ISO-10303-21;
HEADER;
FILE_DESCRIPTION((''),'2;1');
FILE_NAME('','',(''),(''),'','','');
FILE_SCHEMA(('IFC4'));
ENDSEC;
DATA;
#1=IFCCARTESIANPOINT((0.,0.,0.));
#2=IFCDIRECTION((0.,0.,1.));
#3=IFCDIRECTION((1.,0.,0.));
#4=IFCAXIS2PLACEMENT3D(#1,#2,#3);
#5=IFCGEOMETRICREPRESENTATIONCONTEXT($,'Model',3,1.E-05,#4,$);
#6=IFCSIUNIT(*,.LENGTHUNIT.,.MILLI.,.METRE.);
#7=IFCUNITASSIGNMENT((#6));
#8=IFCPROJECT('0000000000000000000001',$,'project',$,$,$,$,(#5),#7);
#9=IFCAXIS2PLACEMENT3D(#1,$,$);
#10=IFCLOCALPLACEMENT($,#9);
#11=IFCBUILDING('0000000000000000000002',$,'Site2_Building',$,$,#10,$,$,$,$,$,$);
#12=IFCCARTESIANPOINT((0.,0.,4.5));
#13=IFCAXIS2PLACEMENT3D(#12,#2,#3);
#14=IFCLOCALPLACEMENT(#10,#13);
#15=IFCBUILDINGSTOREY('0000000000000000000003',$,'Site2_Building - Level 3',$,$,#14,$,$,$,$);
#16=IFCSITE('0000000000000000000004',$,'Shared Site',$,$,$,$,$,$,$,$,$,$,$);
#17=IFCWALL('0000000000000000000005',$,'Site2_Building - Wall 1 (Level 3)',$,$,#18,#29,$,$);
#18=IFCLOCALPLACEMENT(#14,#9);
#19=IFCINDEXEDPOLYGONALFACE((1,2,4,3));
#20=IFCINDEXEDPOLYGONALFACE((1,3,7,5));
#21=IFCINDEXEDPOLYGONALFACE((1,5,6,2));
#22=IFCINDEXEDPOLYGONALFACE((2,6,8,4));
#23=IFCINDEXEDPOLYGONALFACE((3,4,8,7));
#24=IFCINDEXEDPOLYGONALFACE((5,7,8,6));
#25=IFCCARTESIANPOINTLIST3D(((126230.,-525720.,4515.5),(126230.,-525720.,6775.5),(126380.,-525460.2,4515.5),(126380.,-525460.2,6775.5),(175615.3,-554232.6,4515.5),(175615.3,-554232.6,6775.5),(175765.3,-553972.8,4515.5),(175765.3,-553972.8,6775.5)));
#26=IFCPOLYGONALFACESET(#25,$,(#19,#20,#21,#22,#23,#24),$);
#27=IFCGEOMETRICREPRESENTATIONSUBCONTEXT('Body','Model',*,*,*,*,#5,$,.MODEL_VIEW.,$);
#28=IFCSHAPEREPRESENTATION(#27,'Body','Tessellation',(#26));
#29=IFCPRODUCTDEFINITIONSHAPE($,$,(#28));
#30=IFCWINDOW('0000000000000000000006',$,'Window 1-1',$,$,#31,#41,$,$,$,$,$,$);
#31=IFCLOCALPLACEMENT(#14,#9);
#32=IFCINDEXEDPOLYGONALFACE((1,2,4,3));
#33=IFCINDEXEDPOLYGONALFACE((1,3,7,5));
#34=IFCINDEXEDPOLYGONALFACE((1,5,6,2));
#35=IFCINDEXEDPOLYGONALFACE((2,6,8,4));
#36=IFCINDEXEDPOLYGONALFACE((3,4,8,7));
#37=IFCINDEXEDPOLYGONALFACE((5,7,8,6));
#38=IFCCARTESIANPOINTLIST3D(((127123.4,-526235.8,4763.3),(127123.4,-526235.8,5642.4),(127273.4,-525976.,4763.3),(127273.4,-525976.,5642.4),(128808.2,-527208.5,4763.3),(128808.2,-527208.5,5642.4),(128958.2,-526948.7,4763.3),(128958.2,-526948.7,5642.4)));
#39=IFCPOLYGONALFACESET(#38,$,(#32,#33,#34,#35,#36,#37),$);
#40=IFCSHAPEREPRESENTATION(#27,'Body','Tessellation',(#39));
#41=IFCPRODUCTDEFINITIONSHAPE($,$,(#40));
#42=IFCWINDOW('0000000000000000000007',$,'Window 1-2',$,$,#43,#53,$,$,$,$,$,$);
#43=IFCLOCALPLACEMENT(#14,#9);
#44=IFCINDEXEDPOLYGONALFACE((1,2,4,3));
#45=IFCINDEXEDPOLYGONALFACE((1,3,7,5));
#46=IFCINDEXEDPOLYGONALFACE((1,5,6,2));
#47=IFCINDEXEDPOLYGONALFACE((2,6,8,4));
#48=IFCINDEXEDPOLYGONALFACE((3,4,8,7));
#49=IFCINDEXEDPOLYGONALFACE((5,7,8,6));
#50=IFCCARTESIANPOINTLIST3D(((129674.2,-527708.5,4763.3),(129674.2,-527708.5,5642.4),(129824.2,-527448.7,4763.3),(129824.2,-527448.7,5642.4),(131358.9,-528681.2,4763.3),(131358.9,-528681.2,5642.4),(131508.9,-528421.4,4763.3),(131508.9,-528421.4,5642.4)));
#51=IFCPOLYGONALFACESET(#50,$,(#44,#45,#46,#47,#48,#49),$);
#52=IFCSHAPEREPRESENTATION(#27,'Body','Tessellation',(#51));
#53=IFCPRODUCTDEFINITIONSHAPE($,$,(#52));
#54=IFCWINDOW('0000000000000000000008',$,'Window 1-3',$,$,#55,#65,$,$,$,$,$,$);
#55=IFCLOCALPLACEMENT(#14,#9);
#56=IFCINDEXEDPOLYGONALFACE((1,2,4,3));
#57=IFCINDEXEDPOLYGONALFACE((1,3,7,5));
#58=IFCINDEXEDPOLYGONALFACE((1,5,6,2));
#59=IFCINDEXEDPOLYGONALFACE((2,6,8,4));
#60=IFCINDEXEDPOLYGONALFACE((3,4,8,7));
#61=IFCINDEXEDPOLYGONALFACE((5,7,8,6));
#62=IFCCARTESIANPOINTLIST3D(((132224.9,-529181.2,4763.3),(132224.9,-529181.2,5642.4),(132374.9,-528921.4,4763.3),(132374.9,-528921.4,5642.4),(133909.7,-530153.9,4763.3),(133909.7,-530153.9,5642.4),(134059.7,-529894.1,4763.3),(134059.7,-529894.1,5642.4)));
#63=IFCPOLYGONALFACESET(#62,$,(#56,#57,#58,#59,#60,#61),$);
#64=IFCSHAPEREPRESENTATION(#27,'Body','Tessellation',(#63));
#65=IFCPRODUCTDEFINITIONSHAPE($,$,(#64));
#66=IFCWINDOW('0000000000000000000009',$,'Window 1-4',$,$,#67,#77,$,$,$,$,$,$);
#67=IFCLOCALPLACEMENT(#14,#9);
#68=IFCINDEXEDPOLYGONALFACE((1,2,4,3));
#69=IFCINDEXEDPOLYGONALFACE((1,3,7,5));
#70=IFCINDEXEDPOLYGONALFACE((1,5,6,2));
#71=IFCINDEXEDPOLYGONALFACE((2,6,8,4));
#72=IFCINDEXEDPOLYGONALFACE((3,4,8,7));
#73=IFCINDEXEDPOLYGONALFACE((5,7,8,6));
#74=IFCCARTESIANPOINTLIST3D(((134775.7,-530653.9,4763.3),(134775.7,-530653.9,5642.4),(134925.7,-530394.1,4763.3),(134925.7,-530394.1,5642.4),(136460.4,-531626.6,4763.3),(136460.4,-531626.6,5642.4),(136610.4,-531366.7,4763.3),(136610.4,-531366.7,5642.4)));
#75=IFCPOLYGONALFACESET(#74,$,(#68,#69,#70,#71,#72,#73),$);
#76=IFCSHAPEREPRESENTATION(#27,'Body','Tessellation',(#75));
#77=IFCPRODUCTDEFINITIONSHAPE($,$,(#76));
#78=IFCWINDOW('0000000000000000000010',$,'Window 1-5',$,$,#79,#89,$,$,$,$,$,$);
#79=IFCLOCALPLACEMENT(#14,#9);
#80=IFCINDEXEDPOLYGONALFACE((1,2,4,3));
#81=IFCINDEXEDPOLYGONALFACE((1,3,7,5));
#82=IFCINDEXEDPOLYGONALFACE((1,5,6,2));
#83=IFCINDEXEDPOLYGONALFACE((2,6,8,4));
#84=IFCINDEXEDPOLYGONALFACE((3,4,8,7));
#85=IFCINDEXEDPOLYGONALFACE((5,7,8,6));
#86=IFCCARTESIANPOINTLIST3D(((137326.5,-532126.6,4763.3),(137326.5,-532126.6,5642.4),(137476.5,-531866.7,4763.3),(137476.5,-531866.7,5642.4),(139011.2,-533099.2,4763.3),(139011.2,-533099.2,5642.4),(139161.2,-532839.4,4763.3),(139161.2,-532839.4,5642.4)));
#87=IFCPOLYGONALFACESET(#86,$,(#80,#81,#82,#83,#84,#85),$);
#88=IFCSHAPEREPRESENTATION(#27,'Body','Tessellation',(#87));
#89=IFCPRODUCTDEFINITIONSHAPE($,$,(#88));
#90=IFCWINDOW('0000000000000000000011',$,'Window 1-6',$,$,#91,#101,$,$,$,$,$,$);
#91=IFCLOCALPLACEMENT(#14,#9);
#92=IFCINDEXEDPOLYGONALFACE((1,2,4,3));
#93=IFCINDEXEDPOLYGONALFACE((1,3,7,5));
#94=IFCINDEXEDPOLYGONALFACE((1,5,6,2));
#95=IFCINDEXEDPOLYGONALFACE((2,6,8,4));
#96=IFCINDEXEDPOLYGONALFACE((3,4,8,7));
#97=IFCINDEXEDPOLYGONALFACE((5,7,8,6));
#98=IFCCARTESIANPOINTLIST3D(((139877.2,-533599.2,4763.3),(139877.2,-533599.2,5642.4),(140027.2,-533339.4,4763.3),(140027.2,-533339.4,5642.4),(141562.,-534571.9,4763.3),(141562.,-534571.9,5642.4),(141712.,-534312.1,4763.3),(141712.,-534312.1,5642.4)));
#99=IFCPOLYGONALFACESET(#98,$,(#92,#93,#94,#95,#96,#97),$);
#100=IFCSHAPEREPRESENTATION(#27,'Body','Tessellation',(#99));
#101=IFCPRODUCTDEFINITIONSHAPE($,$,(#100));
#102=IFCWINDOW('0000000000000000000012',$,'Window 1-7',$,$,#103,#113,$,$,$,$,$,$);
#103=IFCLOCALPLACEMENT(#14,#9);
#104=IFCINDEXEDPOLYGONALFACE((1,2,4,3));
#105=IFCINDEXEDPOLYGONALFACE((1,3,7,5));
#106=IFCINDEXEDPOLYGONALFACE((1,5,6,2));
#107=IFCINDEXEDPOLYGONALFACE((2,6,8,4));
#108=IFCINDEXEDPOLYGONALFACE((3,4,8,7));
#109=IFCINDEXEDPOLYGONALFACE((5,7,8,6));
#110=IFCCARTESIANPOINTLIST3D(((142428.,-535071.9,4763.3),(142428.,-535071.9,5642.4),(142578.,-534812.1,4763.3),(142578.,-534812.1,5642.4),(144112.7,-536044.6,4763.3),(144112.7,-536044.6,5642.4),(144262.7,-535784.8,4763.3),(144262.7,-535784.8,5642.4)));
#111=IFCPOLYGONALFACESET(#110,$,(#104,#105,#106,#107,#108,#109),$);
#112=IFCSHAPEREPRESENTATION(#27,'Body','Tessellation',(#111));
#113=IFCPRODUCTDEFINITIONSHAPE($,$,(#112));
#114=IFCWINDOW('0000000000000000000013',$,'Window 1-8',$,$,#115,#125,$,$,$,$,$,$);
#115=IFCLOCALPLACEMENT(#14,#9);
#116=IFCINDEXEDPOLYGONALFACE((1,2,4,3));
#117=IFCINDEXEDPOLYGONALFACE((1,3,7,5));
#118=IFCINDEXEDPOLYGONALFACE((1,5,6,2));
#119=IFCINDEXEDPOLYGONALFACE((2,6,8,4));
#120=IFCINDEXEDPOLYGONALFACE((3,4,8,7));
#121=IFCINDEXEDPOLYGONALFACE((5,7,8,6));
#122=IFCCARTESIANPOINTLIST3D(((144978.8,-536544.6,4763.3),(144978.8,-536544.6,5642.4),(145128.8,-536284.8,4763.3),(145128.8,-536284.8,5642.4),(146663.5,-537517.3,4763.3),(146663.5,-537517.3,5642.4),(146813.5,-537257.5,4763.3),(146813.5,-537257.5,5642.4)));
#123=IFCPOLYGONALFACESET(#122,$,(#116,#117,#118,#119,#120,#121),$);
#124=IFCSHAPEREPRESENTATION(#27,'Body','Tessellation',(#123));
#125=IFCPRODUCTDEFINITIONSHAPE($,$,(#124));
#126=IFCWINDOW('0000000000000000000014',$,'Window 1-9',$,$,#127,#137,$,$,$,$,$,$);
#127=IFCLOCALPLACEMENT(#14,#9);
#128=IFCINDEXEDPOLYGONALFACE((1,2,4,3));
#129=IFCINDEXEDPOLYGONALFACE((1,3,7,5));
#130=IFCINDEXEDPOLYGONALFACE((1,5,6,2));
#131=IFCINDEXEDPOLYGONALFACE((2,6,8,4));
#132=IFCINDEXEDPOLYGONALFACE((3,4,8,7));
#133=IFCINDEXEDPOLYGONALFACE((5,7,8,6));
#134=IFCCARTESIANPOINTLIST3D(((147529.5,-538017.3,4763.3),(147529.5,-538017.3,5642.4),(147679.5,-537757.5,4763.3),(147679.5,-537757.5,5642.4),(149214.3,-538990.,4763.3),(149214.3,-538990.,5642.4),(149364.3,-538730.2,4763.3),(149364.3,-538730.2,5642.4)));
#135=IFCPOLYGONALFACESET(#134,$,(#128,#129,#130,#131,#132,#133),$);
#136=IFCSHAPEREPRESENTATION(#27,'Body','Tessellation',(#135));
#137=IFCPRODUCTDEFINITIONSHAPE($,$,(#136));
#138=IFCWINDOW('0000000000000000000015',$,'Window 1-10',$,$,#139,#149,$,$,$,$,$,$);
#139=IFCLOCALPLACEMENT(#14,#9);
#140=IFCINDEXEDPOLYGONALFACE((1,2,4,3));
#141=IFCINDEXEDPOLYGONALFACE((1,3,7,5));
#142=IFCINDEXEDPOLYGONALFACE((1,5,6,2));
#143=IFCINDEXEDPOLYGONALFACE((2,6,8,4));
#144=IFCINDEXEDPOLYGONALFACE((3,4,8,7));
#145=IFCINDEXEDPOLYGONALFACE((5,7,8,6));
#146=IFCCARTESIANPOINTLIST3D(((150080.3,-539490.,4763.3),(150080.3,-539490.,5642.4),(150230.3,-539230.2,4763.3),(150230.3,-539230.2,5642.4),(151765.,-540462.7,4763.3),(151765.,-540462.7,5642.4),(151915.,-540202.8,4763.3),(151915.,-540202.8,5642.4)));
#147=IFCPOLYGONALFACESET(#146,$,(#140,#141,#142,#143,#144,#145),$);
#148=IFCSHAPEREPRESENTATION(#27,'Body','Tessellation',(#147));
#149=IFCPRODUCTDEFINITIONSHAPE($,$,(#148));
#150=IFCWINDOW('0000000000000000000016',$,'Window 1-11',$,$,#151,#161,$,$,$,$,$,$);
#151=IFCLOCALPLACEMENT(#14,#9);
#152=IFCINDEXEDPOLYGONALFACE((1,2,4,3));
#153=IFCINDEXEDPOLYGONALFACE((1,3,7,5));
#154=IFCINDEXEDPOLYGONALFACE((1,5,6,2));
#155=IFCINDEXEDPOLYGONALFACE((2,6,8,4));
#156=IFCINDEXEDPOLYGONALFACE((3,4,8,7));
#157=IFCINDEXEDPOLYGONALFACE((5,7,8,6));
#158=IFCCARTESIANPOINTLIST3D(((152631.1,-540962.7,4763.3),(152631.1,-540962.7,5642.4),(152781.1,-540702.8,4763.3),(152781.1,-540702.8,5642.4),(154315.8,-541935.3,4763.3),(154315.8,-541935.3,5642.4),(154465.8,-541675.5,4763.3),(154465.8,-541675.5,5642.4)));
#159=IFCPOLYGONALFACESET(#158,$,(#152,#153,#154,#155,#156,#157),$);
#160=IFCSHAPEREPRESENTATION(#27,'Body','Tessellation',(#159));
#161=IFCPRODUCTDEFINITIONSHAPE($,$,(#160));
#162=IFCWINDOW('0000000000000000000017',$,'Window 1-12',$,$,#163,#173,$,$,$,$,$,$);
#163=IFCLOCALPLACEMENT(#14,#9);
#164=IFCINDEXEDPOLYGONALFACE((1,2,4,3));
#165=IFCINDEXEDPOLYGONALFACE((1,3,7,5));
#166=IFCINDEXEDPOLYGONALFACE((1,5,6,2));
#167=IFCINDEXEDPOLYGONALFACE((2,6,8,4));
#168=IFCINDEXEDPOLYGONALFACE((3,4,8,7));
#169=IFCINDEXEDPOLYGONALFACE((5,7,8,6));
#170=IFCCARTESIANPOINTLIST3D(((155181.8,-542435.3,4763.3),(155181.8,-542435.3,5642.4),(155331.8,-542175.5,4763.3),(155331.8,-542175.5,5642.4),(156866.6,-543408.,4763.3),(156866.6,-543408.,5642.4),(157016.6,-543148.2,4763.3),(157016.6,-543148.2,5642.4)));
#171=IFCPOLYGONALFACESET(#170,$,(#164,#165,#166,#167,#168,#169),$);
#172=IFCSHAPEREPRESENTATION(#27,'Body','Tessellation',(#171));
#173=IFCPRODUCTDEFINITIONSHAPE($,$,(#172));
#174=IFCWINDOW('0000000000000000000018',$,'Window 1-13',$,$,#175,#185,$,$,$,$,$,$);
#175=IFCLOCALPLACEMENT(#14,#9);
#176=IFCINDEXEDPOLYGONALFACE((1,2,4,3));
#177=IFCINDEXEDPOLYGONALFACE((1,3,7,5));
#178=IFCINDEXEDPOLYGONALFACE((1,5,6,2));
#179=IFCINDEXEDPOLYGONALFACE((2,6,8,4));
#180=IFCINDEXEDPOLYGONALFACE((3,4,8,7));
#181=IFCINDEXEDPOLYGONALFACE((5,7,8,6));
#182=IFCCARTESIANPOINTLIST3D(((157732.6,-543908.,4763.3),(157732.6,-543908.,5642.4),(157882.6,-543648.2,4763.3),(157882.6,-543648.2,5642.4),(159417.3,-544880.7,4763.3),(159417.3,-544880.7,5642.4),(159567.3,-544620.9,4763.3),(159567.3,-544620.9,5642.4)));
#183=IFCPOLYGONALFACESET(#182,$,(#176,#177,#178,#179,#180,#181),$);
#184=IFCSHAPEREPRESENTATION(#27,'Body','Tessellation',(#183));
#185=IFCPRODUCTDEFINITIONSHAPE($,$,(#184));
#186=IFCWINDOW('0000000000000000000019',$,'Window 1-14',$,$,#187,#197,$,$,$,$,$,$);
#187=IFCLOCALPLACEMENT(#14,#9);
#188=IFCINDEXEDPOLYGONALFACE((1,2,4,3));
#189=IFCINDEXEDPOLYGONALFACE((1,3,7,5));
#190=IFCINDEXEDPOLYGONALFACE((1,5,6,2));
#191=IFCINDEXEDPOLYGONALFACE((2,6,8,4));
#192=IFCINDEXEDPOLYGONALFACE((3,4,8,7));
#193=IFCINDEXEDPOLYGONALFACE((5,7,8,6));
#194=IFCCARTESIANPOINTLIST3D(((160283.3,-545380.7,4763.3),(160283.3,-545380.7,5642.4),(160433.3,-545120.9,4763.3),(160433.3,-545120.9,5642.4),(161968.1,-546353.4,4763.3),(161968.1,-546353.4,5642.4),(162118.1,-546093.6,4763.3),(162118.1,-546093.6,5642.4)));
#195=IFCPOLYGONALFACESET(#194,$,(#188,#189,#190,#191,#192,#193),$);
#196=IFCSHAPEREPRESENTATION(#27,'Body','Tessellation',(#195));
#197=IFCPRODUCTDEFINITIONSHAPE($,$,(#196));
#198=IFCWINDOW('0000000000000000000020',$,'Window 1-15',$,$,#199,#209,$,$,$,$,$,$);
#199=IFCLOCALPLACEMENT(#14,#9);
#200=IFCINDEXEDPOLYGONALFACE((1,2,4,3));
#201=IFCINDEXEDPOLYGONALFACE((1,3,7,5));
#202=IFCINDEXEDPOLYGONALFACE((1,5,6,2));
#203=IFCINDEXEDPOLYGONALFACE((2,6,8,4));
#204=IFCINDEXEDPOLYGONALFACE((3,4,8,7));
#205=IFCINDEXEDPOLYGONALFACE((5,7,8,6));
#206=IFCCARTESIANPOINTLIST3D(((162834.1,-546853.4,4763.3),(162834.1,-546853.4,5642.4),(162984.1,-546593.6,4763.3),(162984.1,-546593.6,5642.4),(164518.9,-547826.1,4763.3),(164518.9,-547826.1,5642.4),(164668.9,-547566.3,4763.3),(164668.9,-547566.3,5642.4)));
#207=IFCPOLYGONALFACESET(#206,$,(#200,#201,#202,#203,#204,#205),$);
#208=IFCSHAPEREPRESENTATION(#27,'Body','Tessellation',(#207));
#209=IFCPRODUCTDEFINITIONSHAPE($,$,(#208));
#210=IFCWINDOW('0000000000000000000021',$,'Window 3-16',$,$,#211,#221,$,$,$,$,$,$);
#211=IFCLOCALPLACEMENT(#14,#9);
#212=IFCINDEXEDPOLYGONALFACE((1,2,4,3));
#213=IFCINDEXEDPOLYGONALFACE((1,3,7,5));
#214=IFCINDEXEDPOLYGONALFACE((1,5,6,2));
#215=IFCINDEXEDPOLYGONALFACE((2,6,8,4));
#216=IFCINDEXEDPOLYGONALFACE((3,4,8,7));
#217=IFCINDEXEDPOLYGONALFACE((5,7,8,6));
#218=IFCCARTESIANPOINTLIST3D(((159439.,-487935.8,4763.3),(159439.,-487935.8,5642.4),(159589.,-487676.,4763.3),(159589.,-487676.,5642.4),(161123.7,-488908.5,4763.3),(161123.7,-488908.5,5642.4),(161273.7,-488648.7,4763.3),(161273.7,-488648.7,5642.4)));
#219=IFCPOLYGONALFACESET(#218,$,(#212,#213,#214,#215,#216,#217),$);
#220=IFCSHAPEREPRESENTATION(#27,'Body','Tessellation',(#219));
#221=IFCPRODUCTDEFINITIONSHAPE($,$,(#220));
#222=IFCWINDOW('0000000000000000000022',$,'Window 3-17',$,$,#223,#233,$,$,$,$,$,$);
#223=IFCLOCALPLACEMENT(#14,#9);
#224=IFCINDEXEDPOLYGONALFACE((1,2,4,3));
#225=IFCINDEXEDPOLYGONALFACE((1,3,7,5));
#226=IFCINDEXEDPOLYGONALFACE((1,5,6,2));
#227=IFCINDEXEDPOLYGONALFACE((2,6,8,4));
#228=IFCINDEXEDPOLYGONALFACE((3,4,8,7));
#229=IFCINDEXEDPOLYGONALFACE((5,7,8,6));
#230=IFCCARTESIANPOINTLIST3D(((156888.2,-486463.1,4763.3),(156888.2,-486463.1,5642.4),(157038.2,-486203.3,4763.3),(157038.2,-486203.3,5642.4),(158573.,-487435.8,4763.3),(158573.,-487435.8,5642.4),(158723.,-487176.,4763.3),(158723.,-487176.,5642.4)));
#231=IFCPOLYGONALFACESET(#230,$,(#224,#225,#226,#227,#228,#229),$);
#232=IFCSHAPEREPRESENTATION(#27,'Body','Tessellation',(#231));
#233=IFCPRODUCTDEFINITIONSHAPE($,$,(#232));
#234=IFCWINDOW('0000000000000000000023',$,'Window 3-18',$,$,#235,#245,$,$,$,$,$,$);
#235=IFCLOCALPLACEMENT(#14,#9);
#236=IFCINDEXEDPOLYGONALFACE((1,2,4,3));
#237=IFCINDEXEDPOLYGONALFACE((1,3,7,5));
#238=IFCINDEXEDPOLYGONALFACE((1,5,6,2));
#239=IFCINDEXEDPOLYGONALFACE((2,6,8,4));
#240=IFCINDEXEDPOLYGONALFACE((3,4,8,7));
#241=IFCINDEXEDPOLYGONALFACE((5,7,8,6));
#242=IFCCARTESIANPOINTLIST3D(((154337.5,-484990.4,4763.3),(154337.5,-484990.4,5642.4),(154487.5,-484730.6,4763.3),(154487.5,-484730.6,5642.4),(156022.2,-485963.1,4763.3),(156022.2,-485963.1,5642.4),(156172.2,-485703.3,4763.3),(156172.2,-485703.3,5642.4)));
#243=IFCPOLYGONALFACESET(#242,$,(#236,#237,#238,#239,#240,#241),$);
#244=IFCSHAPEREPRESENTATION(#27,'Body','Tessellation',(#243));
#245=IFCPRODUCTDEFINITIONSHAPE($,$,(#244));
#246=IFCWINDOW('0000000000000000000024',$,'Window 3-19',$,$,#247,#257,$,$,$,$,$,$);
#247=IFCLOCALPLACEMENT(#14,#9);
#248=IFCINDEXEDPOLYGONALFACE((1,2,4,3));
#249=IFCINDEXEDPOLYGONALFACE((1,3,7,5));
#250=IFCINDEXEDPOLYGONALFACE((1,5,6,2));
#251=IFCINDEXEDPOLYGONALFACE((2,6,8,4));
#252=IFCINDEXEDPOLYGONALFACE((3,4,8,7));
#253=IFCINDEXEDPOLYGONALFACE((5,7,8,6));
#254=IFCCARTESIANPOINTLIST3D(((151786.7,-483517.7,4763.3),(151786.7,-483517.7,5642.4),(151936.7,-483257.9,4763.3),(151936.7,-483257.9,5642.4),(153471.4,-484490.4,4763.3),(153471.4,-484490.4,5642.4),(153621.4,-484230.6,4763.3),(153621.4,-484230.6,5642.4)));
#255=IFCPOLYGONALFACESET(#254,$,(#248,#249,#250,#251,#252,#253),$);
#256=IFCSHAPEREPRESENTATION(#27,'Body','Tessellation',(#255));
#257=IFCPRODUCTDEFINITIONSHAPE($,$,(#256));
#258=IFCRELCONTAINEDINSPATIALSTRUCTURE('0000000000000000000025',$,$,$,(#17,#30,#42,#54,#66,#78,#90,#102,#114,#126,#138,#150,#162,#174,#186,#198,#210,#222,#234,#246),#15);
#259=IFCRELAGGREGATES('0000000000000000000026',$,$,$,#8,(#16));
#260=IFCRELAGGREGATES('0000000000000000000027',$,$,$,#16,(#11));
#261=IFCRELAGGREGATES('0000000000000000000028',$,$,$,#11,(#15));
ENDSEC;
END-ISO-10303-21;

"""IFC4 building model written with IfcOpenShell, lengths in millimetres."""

from ifc_helpers import new_model, si_unit, frame, origin, origin_with_axes, place, context, subcontext, project, spatial, indexed_curve, outline, extrude, element, save


model = new_model("IFC4")

# Units and contexts
model_context = context("Model", 3, precision=1e-05, world=origin_with_axes())
body_context = subcontext(model_context, "Body", "Model", "MODEL_VIEW")
ifc_project = project(units=[si_unit("LENGTHUNIT", "METRE", prefix="MILLI")], contexts=[model_context])

# Site, building, storey
site = spatial("IfcSite", under=ifc_project, Name="Shared Site")
building_placement = place(None, origin())
building = spatial("IfcBuilding", under=site, at=building_placement, Name="Site2_Building")
storey_placement = place(building_placement, frame((0.0, 0.0, 4.5), z_axis=(0.0, 0.0, 1.0), x_axis=(1.0, 0.0, 0.0)))
storey = spatial("IfcBuildingStorey", under=building, at=storey_placement, Name="Site2_Building - Level 3")

# Wall
wall_1_placement = place(storey_placement, frame((126230.0, -525720.0, 4515.5), z_axis=(0.0, 0.0, 1.0), x_axis=(0.866025, -0.5, 0.0)))
element("IfcWall", 1, at=wall_1_placement, inside=storey, Name="Site2_Building - Wall 1 (Level 3)", context=body_context, shape_type="SweptSolid", body=[
    extrude(outline(indexed_curve([(0.0, 0.0), (0.0, 300.0), (57025.3, 300.0), (57025.3, 0.0), (0.0, 0.0)], self_intersect=False)), origin_with_axes(), (0.0, 0.0, 1.0), 2260.0),
])

# Windows
for number, where, z_axis, x_axis, name in (
    (2, (127123.4, -526235.8, 4763.3), (0.0, 0.0, 1.0), (0.866025, -0.5, 0.0), "Window 1-1"),
    (3, (129674.2, -527708.5, 4763.3), (0.0, 0.0, 1.0), (0.866025, -0.5, 0.0), "Window 1-2"),
    (4, (132224.9, -529181.2, 4763.3), (0.0, 0.0, 1.0), (0.866025, -0.5, 0.0), "Window 1-3"),
    (5, (134775.7, -530653.9, 4763.3), (0.0, 0.0, 1.0), (0.866025, -0.5, 0.0), "Window 1-4"),
    (6, (137326.5, -532126.6, 4763.3), (0.0, 0.0, 1.0), (0.866025, -0.5, 0.0), "Window 1-5"),
    (7, (139877.2, -533599.2, 4763.3), (0.0, 0.0, 1.0), (0.866025, -0.5, 0.0), "Window 1-6"),
    (8, (142428.0, -535071.9, 4763.3), (0.0, 0.0, 1.0), (0.866025, -0.5, 0.0), "Window 1-7"),
    (9, (144978.8, -536544.6, 4763.3), (0.0, 0.0, 1.0), (0.866025, -0.5, 0.0), "Window 1-8"),
    (10, (147529.5, -538017.3, 4763.3), (0.0, 0.0, 1.0), (0.866025, -0.5, 0.0), "Window 1-9"),
    (11, (150080.3, -539490.0, 4763.3), (0.0, 0.0, 1.0), (0.866025, -0.5, 0.0), "Window 1-10"),
    (12, (152631.1, -540962.7, 4763.3), (0.0, 0.0, 1.0), (0.866025, -0.5, 0.0), "Window 1-11"),
    (13, (155181.8, -542435.3, 4763.3), (0.0, 0.0, 1.0), (0.866025, -0.5, 0.0), "Window 1-12"),
    (14, (157732.6, -543908.0, 4763.3), (0.0, 0.0, 1.0), (0.866025, -0.5, 0.0), "Window 1-13"),
    (15, (160283.3, -545380.7, 4763.3), (0.0, 0.0, 1.0), (0.866025, -0.5, 0.0), "Window 1-14"),
    (16, (162834.1, -546853.4, 4763.3), (0.0, 0.0, 1.0), (0.866025, -0.5, 0.0), "Window 1-15"),
    (17, (161273.7, -488648.7, 4763.3), (0.0, 0.0, 1.0), (-0.866025, 0.5, 0.0), "Window 3-16"),
    (18, (158723.0, -487176.0, 4763.3), (0.0, 0.0, 1.0), (-0.866025, 0.5, 0.0), "Window 3-17"),
    (19, (156172.2, -485703.3, 4763.3), (0.0, 0.0, 1.0), (-0.866025, 0.5, 0.0), "Window 3-18"),
    (20, (153621.4, -484230.6, 4763.3), (0.0, 0.0, 1.0), (-0.866025, 0.5, 0.0), "Window 3-19"),
):
    element("IfcWindow", number, at=place(storey_placement, frame(where, z_axis=z_axis, x_axis=x_axis)), inside=storey, Name=name, context=body_context, shape_type="SweptSolid", body=[
        extrude(outline(indexed_curve([(0.0, 0.0), (0.0, 300.0), (1945.4, 300.0), (1945.4, 0.0), (0.0, 0.0)], self_intersect=False)), origin_with_axes(), (0.0, 0.0, 1.0), 879.1),
    ])

save(model, "model.ifc")
